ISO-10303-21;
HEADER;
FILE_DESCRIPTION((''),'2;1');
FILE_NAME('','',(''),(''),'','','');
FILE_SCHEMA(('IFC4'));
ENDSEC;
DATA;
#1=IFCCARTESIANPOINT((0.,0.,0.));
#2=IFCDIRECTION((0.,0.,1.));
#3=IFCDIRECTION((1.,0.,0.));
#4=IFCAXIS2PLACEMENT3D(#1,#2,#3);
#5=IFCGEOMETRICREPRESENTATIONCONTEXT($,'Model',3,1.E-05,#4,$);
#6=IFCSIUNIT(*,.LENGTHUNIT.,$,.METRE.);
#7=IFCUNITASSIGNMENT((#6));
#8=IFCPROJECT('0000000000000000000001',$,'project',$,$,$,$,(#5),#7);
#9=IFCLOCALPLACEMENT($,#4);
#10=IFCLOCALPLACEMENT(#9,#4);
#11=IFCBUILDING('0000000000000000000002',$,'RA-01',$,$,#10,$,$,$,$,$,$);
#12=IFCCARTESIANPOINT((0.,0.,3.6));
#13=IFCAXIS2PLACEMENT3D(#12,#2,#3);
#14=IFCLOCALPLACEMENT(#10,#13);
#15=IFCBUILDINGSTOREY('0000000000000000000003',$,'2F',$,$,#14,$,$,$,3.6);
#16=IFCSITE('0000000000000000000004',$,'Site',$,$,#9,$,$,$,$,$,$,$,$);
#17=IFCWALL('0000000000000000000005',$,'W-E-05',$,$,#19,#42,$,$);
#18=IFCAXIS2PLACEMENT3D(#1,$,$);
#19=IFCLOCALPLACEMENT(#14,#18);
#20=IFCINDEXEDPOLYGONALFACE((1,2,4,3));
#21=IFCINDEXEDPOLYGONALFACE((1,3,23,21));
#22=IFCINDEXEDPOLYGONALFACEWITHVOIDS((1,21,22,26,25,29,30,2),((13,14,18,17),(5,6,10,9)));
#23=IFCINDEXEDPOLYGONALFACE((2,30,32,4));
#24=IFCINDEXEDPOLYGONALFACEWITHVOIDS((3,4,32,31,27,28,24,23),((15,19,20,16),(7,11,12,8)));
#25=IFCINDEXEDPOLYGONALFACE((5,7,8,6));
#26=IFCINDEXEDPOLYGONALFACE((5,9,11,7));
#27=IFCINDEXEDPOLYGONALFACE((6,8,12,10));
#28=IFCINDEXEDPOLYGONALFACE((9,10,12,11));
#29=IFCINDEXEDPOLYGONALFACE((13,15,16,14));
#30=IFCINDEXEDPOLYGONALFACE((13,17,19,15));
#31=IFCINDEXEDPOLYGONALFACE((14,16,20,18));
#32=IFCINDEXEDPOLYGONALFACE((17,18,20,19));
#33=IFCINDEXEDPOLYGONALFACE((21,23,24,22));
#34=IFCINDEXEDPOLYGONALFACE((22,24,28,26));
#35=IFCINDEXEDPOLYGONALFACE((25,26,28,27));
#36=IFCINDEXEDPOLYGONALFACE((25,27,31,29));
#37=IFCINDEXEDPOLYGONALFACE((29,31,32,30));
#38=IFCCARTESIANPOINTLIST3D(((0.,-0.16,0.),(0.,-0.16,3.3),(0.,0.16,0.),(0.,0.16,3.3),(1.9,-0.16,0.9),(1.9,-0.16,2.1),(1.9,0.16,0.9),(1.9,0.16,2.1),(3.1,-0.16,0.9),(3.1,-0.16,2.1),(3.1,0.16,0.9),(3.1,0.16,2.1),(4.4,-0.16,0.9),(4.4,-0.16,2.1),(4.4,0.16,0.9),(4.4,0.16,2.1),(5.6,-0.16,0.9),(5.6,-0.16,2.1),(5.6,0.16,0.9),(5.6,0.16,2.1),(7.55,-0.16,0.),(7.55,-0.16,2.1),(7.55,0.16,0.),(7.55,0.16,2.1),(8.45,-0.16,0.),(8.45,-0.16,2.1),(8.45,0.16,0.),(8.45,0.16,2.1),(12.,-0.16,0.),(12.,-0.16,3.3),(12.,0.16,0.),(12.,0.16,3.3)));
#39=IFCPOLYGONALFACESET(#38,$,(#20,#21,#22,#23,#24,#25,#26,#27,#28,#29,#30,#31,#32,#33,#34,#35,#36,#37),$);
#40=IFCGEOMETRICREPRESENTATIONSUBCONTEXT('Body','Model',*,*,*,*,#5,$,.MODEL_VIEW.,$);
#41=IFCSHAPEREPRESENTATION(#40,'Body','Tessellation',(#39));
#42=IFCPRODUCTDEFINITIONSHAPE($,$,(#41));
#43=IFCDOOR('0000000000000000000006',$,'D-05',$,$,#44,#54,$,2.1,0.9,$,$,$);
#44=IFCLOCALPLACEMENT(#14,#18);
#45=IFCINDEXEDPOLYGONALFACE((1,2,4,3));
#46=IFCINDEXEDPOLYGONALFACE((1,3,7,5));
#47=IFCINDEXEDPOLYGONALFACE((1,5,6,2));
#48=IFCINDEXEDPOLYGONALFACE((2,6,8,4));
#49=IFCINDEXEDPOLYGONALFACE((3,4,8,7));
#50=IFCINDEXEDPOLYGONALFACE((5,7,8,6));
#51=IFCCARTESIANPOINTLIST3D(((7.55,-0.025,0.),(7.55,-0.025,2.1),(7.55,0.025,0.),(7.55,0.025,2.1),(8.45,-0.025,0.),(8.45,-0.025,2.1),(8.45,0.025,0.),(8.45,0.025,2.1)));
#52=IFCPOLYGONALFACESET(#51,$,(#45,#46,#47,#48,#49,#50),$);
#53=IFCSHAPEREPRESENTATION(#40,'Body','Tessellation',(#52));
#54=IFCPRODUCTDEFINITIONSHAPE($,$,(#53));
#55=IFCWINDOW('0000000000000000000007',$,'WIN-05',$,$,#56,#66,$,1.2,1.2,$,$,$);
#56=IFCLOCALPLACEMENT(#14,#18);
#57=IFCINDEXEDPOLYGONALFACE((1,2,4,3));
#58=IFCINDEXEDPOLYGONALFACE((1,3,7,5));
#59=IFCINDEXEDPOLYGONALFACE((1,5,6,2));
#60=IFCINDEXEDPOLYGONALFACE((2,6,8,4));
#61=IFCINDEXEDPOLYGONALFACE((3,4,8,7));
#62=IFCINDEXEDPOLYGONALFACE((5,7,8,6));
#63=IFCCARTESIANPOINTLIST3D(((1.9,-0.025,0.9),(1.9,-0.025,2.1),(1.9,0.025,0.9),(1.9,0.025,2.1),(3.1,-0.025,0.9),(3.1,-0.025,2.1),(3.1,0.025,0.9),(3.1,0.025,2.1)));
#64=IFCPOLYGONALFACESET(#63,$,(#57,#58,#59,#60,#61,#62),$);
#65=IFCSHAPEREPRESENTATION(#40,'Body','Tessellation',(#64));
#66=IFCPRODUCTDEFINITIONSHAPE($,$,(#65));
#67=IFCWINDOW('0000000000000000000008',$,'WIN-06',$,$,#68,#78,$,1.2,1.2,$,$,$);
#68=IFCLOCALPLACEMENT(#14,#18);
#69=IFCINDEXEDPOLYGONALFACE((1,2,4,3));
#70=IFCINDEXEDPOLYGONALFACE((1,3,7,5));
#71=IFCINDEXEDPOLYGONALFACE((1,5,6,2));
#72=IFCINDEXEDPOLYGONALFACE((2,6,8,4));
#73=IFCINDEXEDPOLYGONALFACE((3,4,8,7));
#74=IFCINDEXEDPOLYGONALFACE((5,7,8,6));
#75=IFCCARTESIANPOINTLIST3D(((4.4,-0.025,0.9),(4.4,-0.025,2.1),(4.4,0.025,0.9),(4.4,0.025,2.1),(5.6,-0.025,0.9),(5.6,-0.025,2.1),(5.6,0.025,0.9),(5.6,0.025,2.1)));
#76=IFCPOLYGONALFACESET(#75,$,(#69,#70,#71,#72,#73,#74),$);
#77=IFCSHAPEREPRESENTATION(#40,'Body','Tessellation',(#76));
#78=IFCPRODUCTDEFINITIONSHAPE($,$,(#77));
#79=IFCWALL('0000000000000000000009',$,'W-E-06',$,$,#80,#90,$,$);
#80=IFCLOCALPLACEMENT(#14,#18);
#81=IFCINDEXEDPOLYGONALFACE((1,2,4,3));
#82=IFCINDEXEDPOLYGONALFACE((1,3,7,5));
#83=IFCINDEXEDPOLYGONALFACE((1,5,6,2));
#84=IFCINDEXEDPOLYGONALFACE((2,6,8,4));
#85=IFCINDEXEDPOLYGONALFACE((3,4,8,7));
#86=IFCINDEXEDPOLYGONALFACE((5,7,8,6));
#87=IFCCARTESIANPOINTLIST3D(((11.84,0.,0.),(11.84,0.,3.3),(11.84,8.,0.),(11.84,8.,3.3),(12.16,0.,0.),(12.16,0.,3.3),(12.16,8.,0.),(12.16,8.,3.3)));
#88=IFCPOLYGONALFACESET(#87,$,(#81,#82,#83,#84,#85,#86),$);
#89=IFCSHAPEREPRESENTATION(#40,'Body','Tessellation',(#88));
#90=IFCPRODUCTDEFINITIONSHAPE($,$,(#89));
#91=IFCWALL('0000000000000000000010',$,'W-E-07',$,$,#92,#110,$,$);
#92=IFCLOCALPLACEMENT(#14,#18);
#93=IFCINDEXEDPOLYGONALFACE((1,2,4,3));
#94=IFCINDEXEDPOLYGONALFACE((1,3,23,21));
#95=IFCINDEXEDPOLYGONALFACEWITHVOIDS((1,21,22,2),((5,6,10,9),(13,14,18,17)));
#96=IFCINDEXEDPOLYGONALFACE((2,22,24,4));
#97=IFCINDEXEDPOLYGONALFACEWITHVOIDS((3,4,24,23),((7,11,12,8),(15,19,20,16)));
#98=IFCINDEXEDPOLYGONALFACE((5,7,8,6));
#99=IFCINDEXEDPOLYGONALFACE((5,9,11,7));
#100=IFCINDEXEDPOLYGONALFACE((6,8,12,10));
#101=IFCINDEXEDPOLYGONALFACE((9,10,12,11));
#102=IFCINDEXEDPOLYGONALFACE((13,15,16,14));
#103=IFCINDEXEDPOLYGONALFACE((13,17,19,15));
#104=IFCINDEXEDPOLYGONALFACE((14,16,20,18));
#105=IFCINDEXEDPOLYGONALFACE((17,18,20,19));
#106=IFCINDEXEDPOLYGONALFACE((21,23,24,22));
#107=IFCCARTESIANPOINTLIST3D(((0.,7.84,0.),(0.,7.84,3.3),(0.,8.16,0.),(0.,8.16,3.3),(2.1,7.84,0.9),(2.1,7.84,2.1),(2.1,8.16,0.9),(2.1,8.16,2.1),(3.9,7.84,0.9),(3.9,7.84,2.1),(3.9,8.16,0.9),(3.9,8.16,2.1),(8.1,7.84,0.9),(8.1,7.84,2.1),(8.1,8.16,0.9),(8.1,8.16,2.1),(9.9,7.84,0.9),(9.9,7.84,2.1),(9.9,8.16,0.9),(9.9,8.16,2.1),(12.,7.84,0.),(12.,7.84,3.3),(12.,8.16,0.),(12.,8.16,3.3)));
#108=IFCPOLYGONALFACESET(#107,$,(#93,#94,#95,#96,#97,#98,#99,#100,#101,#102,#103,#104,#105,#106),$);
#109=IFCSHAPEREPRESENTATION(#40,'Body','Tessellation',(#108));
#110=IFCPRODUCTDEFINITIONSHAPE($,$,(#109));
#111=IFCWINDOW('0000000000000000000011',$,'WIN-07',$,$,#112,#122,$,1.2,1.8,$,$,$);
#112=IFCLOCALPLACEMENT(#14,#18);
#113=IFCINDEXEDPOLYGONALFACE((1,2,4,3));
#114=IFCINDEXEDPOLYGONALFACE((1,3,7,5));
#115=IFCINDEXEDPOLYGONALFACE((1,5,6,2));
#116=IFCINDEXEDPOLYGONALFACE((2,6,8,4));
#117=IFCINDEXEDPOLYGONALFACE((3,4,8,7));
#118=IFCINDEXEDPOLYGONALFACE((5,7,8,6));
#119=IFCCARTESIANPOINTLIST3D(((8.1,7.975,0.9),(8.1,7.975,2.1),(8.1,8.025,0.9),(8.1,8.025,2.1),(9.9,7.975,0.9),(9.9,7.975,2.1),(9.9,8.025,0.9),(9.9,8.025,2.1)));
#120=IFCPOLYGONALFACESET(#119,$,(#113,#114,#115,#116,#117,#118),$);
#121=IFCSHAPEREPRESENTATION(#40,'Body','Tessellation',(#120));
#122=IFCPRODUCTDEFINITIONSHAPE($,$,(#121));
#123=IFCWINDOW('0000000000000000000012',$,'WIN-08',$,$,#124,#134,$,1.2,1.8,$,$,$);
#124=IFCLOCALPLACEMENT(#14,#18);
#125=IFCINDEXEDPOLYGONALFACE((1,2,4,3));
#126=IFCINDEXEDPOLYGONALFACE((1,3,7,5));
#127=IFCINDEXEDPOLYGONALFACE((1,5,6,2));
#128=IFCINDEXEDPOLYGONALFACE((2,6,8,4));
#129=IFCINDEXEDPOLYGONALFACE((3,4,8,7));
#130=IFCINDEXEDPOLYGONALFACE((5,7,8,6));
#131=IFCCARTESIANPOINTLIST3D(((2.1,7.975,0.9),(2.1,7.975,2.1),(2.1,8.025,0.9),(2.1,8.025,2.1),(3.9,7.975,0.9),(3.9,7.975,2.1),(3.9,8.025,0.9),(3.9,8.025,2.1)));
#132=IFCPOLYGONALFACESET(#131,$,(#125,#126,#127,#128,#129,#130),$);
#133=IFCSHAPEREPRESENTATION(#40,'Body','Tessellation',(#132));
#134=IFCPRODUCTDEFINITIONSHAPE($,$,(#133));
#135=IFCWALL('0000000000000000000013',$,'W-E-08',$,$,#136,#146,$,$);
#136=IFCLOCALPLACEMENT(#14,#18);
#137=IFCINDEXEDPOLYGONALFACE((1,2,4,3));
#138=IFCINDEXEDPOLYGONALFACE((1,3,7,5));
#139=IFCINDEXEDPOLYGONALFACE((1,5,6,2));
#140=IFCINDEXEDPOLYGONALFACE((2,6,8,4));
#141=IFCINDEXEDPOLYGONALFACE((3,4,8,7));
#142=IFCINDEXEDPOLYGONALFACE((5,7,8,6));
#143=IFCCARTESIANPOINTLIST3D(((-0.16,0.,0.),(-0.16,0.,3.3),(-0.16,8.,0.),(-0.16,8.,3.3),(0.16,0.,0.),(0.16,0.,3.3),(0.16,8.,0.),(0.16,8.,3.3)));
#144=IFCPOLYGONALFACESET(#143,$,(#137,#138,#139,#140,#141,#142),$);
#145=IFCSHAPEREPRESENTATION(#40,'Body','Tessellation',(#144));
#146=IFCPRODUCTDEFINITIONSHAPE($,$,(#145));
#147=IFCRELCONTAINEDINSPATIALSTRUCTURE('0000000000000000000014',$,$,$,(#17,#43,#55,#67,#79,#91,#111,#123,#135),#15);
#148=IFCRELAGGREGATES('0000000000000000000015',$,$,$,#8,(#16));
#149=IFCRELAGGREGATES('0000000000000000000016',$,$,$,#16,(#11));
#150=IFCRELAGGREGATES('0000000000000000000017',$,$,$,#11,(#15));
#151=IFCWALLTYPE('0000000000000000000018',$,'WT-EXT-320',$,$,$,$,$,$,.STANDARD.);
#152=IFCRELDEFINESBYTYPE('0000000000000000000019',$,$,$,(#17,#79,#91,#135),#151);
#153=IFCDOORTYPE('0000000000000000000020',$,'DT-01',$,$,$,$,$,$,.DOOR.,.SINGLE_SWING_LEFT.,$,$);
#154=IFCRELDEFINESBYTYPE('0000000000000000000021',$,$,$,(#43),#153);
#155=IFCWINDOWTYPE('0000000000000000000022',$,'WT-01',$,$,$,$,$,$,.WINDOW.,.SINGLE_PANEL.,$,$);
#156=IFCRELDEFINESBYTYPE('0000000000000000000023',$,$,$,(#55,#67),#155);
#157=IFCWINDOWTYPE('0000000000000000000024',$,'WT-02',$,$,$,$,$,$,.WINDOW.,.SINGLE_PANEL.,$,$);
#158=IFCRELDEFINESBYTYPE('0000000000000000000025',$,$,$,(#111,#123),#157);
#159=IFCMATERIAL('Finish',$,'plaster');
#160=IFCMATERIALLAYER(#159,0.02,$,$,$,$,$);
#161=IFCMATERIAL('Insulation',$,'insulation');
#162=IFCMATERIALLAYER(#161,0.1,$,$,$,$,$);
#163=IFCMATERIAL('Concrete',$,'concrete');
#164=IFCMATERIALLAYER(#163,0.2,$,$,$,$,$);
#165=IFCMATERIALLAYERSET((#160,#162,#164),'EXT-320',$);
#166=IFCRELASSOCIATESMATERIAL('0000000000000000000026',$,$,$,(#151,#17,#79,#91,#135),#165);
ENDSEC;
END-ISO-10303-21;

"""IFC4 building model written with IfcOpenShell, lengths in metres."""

from ifc_helpers import new_model, si_unit, frame, frame_2d, origin_with_axes, origin_2d_with_axis, place, context, subcontext, project, spatial, rectangle, extrude, material, layer, layer_set, layer_usage, type_object, element, fill, save


model = new_model("IFC4")

# Units and contexts
model_context = context("Model", 3, precision=1e-05, world=origin_with_axes())
body_context = subcontext(model_context, "Body", "Model", "MODEL_VIEW")
ifc_project = project(units=[si_unit("LENGTHUNIT", "METRE")], contexts=[model_context])

# Site, building, storey
site_placement = place(None, origin_with_axes())
site = spatial("IfcSite", under=ifc_project, at=site_placement, Name="Site")
building_placement = place(site_placement, origin_with_axes())
building = spatial("IfcBuilding", under=site, at=building_placement, Name="RA-01")
storey_placement = place(building_placement, frame((0.0, 0.0, 3.6), z_axis=(0.0, 0.0, 1.0), x_axis=(1.0, 0.0, 0.0)))
storey = spatial("IfcBuildingStorey", under=building, at=storey_placement, Name="2F", Elevation=3.6)

# Shared definitions
ifc_material_1 = material(Name="Concrete", Category="concrete")

# Wall, openings, door, windows
ifc_material_2 = material(Name="Finish", Category="plaster")
ifc_layer_1 = layer(ifc_material_2, 0.02)
ifc_material_3 = material(Name="Insulation", Category="insulation")
ifc_layer_2 = layer(ifc_material_3, 0.1)
ifc_layer_3 = layer(ifc_material_1, 0.2)
ifc_layer_set_1 = layer_set([ifc_layer_1, ifc_layer_2, ifc_layer_3], Name="EXT-320")
ifc_layer_usage_1 = layer_usage(ifc_layer_set_1, "AXIS2", "POSITIVE", -0.16)
wall_type_1 = type_object("IfcWallType", Name="WT-EXT-320", PredefinedType="STANDARD", material=ifc_layer_set_1)
wall_1_placement = place(storey_placement, origin_with_axes())
wall_1 = element("IfcWall", 1, at=wall_1_placement, inside=storey, type_object=wall_type_1, material=ifc_layer_usage_1, Name="W-E-05", context=body_context, shape_type="SweptSolid", body=[
    extrude(rectangle(XDim=12.0, YDim=0.32, at=frame_2d((6.0, 0.0), x_axis=(1.0, 0.0))), origin_with_axes(), (0.0, 0.0, 1.0), 3.3),
])
opening_1_placement = place(wall_1_placement, frame((8.0, 0.0, 0.0), z_axis=(0.0, 0.0, 1.0), x_axis=(1.0, 0.0, 0.0)))
opening_1 = element("IfcOpeningElement", 2, at=opening_1_placement, cuts=wall_1, PredefinedType="OPENING", context=body_context, shape_type="SweptSolid", body=[
    extrude(rectangle(XDim=0.9, YDim=0.42, at=origin_2d_with_axis()), origin_with_axes(), (0.0, 0.0, 1.0), 2.1),
])
opening_2_placement = place(wall_1_placement, frame((2.5, 0.0, 0.9), z_axis=(0.0, 0.0, 1.0), x_axis=(1.0, 0.0, 0.0)))
opening_2 = element("IfcOpeningElement", 3, at=opening_2_placement, cuts=wall_1, PredefinedType="OPENING", context=body_context, shape_type="SweptSolid", body=[
    extrude(rectangle(XDim=1.2, YDim=0.42, at=origin_2d_with_axis()), origin_with_axes(), (0.0, 0.0, 1.0), 1.2),
])
opening_3_placement = place(wall_1_placement, frame((5.0, 0.0, 0.9), z_axis=(0.0, 0.0, 1.0), x_axis=(1.0, 0.0, 0.0)))
opening_3 = element("IfcOpeningElement", 4, at=opening_3_placement, cuts=wall_1, PredefinedType="OPENING", context=body_context, shape_type="SweptSolid", body=[
    extrude(rectangle(XDim=1.2, YDim=0.42, at=origin_2d_with_axis()), origin_with_axes(), (0.0, 0.0, 1.0), 1.2),
])
door_type_1 = type_object("IfcDoorType", Name="DT-01", OperationType="SINGLE_SWING_LEFT", PredefinedType="DOOR")
door_1_placement = place(opening_1_placement, origin_with_axes())
door_1 = element("IfcDoor", 5, at=door_1_placement, inside=storey, type_object=door_type_1, Name="D-05", OverallHeight=2.1, OverallWidth=0.9, context=body_context, shape_type="SweptSolid", body=[
    extrude(rectangle(XDim=0.9, YDim=0.05, at=origin_2d_with_axis()), origin_with_axes(), (0.0, 0.0, 1.0), 2.1),
])
fill(opening_1, door_1)
window_type_1 = type_object("IfcWindowType", Name="WT-01", PartitioningType="SINGLE_PANEL", PredefinedType="WINDOW")
window_1_placement = place(opening_2_placement, origin_with_axes())
window_1 = element("IfcWindow", 6, at=window_1_placement, inside=storey, type_object=window_type_1, Name="WIN-05", OverallHeight=1.2, OverallWidth=1.2, context=body_context, shape_type="SweptSolid", body=[
    extrude(rectangle(XDim=1.2, YDim=0.05, at=origin_2d_with_axis()), origin_with_axes(), (0.0, 0.0, 1.0), 1.2),
])
fill(opening_2, window_1)
window_2_placement = place(opening_3_placement, origin_with_axes())
window_2 = element("IfcWindow", 7, at=window_2_placement, inside=storey, type_object=window_type_1, Name="WIN-06", OverallHeight=1.2, OverallWidth=1.2, context=body_context, shape_type="SweptSolid", body=[
    extrude(rectangle(XDim=1.2, YDim=0.05, at=origin_2d_with_axis()), origin_with_axes(), (0.0, 0.0, 1.0), 1.2),
])
fill(opening_3, window_2)

# Wall
ifc_layer_usage_2 = layer_usage(ifc_layer_set_1, "AXIS2", "POSITIVE", -0.16)
wall_2_placement = place(storey_placement, frame((12.0, 0.0, 0.0), z_axis=(0.0, 0.0, 1.0), x_axis=(0.0, 1.0, 0.0)))
element("IfcWall", 8, at=wall_2_placement, inside=storey, type_object=wall_type_1, material=ifc_layer_usage_2, Name="W-E-06", context=body_context, shape_type="SweptSolid", body=[
    extrude(rectangle(XDim=8.0, YDim=0.32, at=frame_2d((4.0, 0.0), x_axis=(1.0, 0.0))), origin_with_axes(), (0.0, 0.0, 1.0), 3.3),
])

# Wall, openings, windows
ifc_layer_usage_3 = layer_usage(ifc_layer_set_1, "AXIS2", "POSITIVE", -0.16)
wall_3_placement = place(storey_placement, frame((12.0, 8.0, 0.0), z_axis=(0.0, 0.0, 1.0), x_axis=(-1.0, 0.0, 0.0)))
wall_3 = element("IfcWall", 9, at=wall_3_placement, inside=storey, type_object=wall_type_1, material=ifc_layer_usage_3, Name="W-E-07", context=body_context, shape_type="SweptSolid", body=[
    extrude(rectangle(XDim=12.0, YDim=0.32, at=frame_2d((6.0, 0.0), x_axis=(1.0, 0.0))), origin_with_axes(), (0.0, 0.0, 1.0), 3.3),
])
opening_4_placement = place(wall_3_placement, frame((3.0, 0.0, 0.9), z_axis=(0.0, 0.0, 1.0), x_axis=(1.0, 0.0, 0.0)))
opening_4 = element("IfcOpeningElement", 10, at=opening_4_placement, cuts=wall_3, PredefinedType="OPENING", context=body_context, shape_type="SweptSolid", body=[
    extrude(rectangle(XDim=1.8, YDim=0.42, at=origin_2d_with_axis()), origin_with_axes(), (0.0, 0.0, 1.0), 1.2),
])
opening_5_placement = place(wall_3_placement, frame((9.0, 0.0, 0.9), z_axis=(0.0, 0.0, 1.0), x_axis=(1.0, 0.0, 0.0)))
opening_5 = element("IfcOpeningElement", 11, at=opening_5_placement, cuts=wall_3, PredefinedType="OPENING", context=body_context, shape_type="SweptSolid", body=[
    extrude(rectangle(XDim=1.8, YDim=0.42, at=origin_2d_with_axis()), origin_with_axes(), (0.0, 0.0, 1.0), 1.2),
])
window_type_2 = type_object("IfcWindowType", Name="WT-02", PartitioningType="SINGLE_PANEL", PredefinedType="WINDOW")
window_3_placement = place(opening_4_placement, origin_with_axes())
window_3 = element("IfcWindow", 12, at=window_3_placement, inside=storey, type_object=window_type_2, Name="WIN-07", OverallHeight=1.2, OverallWidth=1.8, context=body_context, shape_type="SweptSolid", body=[
    extrude(rectangle(XDim=1.8, YDim=0.05, at=origin_2d_with_axis()), origin_with_axes(), (0.0, 0.0, 1.0), 1.2),
])
fill(opening_4, window_3)
window_4_placement = place(opening_5_placement, origin_with_axes())
window_4 = element("IfcWindow", 13, at=window_4_placement, inside=storey, type_object=window_type_2, Name="WIN-08", OverallHeight=1.2, OverallWidth=1.8, context=body_context, shape_type="SweptSolid", body=[
    extrude(rectangle(XDim=1.8, YDim=0.05, at=origin_2d_with_axis()), origin_with_axes(), (0.0, 0.0, 1.0), 1.2),
])
fill(opening_5, window_4)

# Wall
ifc_layer_usage_4 = layer_usage(ifc_layer_set_1, "AXIS2", "POSITIVE", -0.16)
wall_4_placement = place(storey_placement, frame((0.0, 8.0, 0.0), z_axis=(0.0, 0.0, 1.0), x_axis=(0.0, -1.0, 0.0)))
element("IfcWall", 14, at=wall_4_placement, inside=storey, type_object=wall_type_1, material=ifc_layer_usage_4, Name="W-E-08", context=body_context, shape_type="SweptSolid", body=[
    extrude(rectangle(XDim=8.0, YDim=0.32, at=frame_2d((4.0, 0.0), x_axis=(1.0, 0.0))), origin_with_axes(), (0.0, 0.0, 1.0), 3.3),
])

save(model, "model.ifc")
